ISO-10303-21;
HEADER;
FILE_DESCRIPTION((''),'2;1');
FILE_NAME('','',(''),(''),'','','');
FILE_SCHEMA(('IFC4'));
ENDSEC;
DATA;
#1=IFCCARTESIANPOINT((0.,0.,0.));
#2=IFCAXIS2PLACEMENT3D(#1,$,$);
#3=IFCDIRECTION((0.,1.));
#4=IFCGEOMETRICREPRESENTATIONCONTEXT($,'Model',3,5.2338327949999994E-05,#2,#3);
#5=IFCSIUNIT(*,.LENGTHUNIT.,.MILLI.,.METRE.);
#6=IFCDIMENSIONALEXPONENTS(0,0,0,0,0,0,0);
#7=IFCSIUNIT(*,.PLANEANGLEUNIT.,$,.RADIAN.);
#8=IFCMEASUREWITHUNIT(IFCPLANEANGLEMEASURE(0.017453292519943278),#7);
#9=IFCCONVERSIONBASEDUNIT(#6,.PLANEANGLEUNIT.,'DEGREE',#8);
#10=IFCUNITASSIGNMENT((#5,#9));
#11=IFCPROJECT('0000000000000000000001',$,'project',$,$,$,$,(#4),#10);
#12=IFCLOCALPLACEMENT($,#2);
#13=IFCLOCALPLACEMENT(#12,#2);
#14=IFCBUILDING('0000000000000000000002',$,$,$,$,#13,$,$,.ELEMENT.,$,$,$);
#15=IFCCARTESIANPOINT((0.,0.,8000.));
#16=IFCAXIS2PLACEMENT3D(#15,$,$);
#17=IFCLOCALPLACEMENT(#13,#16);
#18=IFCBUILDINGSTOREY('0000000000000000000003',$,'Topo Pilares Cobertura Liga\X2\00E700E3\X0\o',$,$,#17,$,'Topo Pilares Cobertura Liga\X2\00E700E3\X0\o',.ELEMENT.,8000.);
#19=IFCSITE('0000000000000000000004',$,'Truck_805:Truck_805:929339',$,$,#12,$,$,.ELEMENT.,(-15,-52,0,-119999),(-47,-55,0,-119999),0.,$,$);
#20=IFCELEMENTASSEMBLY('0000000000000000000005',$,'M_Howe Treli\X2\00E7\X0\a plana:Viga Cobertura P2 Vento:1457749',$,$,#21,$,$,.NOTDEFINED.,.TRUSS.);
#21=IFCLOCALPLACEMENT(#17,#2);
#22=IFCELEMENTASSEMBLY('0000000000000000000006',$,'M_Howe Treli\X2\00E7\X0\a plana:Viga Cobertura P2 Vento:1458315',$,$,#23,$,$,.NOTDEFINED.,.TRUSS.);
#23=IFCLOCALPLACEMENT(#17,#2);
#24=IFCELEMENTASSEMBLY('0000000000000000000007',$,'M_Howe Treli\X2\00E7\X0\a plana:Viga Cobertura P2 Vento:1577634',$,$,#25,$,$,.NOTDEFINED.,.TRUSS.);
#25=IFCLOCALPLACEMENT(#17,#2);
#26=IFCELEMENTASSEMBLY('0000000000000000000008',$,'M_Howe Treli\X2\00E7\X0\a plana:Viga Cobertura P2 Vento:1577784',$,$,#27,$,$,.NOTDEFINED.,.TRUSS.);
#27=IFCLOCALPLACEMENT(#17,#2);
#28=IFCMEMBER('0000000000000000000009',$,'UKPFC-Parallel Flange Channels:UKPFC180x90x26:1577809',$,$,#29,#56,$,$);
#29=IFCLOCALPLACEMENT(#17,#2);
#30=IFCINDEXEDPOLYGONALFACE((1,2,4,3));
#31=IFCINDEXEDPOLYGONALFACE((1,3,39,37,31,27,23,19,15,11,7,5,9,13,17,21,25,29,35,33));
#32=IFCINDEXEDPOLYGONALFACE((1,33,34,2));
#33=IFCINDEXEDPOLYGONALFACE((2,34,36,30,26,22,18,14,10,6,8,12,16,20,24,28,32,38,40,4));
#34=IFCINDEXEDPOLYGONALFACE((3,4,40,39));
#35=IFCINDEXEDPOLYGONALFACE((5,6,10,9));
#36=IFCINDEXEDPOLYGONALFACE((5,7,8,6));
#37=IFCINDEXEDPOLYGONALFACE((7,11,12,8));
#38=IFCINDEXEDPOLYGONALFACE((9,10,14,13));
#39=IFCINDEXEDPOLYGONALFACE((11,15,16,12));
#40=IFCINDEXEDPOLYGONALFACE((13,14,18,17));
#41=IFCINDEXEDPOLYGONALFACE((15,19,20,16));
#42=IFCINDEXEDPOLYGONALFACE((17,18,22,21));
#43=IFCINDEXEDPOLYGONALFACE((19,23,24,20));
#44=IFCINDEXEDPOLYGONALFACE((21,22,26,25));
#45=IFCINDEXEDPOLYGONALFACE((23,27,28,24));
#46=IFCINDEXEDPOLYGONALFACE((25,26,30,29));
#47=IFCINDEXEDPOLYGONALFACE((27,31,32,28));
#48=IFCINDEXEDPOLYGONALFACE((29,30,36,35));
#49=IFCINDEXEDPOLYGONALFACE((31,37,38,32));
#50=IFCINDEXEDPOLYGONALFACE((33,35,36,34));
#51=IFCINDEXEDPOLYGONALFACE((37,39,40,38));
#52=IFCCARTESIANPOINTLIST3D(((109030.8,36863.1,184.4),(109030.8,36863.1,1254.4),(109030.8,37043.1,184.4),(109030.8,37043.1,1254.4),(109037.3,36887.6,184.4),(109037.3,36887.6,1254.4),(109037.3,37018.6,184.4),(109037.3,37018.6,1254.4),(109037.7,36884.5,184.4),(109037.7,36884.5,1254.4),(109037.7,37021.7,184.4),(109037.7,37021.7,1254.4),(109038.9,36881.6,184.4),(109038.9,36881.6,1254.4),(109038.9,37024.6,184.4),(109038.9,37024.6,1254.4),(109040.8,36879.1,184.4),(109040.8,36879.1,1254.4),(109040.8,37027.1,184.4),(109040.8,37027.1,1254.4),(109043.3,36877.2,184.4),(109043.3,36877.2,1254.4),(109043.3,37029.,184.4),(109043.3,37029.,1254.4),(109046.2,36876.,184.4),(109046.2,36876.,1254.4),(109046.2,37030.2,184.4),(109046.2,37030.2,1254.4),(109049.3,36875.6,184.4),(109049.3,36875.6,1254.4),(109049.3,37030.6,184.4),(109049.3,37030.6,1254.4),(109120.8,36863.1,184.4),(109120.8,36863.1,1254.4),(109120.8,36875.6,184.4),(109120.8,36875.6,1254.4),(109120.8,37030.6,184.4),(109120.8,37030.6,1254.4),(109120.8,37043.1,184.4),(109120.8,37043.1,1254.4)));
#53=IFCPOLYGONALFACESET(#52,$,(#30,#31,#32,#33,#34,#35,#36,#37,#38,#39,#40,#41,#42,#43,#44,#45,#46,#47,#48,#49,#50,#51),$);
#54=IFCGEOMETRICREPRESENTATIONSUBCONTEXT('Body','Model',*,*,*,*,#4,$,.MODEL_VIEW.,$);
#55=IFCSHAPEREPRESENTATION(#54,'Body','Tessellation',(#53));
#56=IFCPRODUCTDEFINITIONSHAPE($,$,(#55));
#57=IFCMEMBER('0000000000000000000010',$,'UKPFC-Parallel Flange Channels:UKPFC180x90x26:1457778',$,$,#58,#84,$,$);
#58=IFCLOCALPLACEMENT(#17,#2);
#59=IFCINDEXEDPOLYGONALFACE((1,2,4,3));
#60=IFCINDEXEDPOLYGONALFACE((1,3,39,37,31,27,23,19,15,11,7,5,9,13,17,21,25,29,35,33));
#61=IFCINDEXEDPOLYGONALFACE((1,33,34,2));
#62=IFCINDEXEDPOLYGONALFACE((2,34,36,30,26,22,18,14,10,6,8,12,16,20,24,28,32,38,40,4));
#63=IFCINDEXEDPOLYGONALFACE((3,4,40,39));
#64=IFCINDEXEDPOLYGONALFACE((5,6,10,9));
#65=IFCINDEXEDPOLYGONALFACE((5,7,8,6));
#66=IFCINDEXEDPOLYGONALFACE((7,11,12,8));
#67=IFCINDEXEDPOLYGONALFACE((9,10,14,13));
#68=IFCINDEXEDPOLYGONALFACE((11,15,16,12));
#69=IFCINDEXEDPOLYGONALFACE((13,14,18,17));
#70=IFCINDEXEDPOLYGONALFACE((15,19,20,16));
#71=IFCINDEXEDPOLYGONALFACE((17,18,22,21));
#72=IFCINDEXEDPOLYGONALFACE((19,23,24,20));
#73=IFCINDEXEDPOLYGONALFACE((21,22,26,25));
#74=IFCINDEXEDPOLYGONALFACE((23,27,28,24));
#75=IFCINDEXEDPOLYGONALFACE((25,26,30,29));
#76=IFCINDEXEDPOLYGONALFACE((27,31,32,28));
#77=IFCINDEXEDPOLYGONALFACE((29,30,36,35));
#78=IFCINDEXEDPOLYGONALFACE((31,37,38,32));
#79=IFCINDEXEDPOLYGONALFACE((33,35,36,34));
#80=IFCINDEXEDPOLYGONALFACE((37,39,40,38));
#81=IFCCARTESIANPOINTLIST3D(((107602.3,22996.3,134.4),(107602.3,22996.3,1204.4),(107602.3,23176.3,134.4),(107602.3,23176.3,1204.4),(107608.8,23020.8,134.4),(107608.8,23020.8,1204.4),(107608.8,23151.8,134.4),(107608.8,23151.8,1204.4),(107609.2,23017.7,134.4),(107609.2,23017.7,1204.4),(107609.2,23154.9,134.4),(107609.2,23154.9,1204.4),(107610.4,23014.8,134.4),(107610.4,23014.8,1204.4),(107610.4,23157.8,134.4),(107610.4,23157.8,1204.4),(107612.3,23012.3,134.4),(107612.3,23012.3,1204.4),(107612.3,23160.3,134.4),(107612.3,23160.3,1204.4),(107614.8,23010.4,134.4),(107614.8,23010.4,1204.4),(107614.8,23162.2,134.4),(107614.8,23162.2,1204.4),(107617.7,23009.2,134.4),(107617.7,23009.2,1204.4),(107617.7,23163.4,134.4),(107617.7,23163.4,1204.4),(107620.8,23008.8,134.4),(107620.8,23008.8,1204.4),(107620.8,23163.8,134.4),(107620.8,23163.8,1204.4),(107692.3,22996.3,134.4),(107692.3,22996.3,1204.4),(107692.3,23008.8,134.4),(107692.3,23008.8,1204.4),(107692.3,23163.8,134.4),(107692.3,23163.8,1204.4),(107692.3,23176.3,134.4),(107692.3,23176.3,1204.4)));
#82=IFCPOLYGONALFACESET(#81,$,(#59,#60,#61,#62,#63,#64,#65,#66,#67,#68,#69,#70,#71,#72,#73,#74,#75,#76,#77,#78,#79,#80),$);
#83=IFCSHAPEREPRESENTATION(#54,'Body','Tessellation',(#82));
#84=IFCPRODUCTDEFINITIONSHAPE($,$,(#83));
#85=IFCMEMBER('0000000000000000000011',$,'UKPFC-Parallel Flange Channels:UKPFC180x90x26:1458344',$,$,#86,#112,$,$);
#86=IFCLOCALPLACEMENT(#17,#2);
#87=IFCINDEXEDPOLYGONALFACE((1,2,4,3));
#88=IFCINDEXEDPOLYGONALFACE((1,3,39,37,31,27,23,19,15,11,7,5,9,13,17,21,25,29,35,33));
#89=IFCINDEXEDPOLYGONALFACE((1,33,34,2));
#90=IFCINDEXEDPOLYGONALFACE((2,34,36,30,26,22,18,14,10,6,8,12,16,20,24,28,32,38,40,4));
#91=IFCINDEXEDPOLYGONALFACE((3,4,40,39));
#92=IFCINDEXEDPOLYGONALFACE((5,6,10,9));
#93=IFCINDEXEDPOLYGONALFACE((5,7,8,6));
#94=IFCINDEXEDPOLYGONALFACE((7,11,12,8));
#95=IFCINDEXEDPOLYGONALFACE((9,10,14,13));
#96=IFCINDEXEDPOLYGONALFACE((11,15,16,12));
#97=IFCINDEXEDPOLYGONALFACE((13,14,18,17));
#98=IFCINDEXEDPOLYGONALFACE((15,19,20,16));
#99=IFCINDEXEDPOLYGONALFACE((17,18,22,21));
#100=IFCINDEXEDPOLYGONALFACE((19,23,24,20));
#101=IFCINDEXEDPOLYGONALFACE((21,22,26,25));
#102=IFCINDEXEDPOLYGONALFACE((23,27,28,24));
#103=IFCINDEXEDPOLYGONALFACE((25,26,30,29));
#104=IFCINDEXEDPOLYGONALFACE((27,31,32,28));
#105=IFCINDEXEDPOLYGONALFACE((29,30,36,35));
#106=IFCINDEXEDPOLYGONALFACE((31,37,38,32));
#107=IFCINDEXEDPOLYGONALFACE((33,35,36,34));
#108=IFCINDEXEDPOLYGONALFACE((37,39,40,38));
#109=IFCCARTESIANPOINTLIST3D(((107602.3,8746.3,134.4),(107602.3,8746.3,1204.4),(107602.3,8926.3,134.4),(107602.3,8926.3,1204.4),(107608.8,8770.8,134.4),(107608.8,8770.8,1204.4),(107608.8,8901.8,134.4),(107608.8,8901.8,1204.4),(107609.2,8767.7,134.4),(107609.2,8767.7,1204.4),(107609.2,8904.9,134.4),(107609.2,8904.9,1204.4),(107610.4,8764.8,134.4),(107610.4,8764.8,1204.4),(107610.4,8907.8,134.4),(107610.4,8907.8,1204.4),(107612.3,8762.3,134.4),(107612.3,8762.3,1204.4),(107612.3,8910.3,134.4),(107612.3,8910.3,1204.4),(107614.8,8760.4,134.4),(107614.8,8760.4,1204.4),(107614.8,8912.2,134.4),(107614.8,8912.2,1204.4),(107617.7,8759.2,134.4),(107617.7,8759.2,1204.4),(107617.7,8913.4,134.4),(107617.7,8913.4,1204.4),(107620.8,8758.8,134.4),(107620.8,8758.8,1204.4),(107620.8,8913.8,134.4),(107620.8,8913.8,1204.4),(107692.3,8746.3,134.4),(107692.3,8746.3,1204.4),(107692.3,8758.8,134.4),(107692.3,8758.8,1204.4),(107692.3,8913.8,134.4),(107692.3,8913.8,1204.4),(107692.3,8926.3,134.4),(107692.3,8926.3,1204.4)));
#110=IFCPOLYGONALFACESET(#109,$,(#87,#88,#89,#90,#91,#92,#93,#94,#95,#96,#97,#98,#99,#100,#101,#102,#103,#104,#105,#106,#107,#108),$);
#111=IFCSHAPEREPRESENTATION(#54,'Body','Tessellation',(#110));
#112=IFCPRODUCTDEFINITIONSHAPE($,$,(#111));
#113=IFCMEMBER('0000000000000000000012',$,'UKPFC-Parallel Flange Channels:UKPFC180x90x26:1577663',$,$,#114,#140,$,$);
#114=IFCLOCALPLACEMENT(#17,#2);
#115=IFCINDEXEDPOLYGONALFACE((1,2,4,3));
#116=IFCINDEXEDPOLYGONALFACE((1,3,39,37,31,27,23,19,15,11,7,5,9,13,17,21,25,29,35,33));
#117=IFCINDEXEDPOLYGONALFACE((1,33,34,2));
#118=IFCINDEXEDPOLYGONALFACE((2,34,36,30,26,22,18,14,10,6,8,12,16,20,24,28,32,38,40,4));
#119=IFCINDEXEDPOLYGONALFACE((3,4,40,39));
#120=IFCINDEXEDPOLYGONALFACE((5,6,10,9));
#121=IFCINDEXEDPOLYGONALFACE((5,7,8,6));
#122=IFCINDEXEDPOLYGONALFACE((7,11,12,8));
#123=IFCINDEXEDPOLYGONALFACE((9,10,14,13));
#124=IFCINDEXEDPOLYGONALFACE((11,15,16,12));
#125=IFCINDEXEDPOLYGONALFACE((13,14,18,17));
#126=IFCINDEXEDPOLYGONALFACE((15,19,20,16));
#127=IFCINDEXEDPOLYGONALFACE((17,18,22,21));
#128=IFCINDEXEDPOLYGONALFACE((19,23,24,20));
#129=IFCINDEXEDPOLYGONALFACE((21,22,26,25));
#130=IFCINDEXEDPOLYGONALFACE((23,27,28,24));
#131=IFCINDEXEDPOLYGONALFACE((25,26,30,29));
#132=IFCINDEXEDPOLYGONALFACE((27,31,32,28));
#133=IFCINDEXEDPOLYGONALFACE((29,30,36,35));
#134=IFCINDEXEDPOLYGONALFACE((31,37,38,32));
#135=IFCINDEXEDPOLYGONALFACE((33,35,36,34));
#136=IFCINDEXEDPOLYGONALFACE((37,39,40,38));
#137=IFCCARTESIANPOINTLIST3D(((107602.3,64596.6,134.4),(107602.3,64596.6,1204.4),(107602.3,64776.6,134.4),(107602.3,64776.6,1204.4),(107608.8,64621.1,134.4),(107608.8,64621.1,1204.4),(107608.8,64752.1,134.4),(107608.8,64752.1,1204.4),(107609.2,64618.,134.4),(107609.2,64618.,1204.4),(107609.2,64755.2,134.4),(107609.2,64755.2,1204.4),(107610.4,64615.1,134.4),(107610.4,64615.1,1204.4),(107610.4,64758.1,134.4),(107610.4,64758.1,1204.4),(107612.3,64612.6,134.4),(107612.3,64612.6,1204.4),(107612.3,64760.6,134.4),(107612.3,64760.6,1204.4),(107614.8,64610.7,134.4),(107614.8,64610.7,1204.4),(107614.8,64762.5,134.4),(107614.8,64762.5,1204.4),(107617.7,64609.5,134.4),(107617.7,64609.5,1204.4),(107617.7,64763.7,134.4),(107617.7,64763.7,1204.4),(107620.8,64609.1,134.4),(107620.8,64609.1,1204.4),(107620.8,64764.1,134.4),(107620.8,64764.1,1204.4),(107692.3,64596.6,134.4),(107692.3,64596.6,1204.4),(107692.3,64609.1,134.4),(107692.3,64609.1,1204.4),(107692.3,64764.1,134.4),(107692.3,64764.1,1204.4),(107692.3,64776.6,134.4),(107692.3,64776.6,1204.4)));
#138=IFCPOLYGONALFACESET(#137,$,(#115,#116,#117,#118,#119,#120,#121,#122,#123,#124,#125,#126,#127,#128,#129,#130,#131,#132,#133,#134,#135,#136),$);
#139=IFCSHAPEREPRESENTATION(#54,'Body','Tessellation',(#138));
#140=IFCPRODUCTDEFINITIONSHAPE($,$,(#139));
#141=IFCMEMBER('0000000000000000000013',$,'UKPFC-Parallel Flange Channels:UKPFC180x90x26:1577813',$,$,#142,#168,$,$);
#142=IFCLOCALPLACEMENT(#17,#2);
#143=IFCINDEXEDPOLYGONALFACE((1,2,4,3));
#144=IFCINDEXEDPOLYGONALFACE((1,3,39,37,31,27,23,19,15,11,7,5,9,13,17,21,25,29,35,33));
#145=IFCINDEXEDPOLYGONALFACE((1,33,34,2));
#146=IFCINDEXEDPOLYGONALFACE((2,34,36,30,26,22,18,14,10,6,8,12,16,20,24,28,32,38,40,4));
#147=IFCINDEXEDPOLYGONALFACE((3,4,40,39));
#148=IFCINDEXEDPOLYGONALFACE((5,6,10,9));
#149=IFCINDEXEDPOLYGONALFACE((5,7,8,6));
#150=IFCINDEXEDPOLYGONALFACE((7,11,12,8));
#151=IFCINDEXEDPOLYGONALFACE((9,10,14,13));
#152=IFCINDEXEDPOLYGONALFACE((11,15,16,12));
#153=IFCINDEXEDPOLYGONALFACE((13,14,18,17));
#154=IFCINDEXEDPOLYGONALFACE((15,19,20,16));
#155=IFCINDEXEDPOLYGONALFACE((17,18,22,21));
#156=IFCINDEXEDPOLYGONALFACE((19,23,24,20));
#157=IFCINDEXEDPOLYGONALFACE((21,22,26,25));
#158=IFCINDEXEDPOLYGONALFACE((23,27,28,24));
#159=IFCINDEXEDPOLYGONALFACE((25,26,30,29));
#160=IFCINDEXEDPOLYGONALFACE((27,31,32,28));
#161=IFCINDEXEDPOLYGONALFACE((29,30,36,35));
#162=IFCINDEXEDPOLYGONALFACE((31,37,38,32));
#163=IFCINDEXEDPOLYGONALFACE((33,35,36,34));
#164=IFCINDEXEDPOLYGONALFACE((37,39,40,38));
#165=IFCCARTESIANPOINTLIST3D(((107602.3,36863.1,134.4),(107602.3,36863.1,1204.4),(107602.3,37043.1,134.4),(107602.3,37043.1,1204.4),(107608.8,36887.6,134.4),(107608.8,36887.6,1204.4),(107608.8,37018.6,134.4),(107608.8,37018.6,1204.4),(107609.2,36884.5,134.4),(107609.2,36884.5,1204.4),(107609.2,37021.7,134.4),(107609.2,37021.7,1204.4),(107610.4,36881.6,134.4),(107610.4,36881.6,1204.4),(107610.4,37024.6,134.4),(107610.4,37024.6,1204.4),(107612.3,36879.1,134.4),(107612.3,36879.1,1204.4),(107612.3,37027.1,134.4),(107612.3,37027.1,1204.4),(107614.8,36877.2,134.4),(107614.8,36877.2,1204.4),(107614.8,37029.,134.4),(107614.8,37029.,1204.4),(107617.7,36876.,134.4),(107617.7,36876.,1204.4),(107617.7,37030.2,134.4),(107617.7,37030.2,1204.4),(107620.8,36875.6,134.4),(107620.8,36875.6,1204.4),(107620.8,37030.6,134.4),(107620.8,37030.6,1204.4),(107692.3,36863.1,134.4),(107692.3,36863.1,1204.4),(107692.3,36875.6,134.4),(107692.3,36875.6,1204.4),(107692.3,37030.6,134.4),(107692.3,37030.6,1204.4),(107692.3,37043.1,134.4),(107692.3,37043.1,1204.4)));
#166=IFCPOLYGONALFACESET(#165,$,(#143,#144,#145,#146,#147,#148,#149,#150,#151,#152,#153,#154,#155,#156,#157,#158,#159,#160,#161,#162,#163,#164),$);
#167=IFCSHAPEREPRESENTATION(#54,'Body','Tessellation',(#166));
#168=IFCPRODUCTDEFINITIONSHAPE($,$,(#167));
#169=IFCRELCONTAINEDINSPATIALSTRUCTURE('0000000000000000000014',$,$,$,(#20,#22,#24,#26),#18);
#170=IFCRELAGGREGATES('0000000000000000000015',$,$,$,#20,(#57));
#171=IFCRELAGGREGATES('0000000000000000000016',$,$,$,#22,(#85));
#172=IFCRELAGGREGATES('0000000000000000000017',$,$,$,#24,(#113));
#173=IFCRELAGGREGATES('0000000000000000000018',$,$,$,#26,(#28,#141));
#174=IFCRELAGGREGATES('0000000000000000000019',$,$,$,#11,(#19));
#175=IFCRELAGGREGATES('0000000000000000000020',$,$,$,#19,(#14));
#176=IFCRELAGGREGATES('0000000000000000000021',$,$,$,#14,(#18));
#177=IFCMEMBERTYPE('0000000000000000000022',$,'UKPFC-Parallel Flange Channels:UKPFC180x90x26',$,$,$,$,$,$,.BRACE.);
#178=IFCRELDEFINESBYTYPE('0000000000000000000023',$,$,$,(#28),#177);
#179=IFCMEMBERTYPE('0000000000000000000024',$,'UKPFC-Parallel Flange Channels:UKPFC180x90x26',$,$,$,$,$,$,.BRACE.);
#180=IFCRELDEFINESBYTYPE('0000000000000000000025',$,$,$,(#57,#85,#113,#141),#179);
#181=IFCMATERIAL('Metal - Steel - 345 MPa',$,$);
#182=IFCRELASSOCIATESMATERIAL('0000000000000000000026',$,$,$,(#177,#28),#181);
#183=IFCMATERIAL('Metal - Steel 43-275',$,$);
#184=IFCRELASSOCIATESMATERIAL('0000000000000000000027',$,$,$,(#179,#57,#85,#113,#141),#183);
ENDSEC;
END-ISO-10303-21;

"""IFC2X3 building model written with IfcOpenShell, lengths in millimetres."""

from ifc_helpers import new_model, entity, si_unit, converted_unit, direction, frame, frame_2d, origin, place, context, subcontext, project, spatial, polyline, circle_curve, parameter, trimmed, segment, composite_curve, outline, extrude, source, transform, mapped, material, type_object, type_shapes, element, aggregate, save


model = new_model("IFC2X3")

# Units and contexts
model_context = context("Model", 3, precision=5.2338327949999994e-05, world=origin(), true_north=direction((0.0, 1.0)))
body_context = subcontext(model_context, "Body", "Model", "MODEL_VIEW")
ifc_project = project(units=[si_unit("LENGTHUNIT", "METRE", prefix="MILLI"), converted_unit("PLANEANGLEUNIT", "DEGREE", entity("IfcPlaneAngleMeasure", 0.017453292519943278), si_unit("PLANEANGLEUNIT", "RADIAN"), dimensions=[0, 0, 0, 0, 0, 0, 0])], contexts=[model_context])

# Site, building, storey
site_placement = place(None, origin())
site = spatial("IfcSite", under=ifc_project, at=site_placement, Name="Truck_805:Truck_805:929339", CompositionType="ELEMENT", RefLatitude=(-15, -52, 0, -119999), RefLongitude=(-47, -55, 0, -119999), RefElevation=0.0)
building_placement = place(site_placement, origin())
building = spatial("IfcBuilding", under=site, at=building_placement, CompositionType="ELEMENT")
storey_placement = place(building_placement, frame((0.0, 0.0, 8000.0)))
storey = spatial("IfcBuildingStorey", under=building, at=storey_placement, Name="Topo Pilares Cobertura Ligação", LongName="Topo Pilares Cobertura Ligação", CompositionType="ELEMENT", Elevation=8000.0)

# Element assemblies
assembly_1_placement = place(storey_placement, origin())
assembly_1 = element("IfcElementAssembly", 1, at=assembly_1_placement, inside=storey, Name="M_Howe Treliça plana:Viga Cobertura P2 Vento:1457749", AssemblyPlace="NOTDEFINED", PredefinedType="TRUSS")
assembly_2_placement = place(storey_placement, origin())
assembly_2 = element("IfcElementAssembly", 2, at=assembly_2_placement, inside=storey, Name="M_Howe Treliça plana:Viga Cobertura P2 Vento:1458315", AssemblyPlace="NOTDEFINED", PredefinedType="TRUSS")
assembly_3_placement = place(storey_placement, origin())
assembly_3 = element("IfcElementAssembly", 3, at=assembly_3_placement, inside=storey, Name="M_Howe Treliça plana:Viga Cobertura P2 Vento:1577634", AssemblyPlace="NOTDEFINED", PredefinedType="TRUSS")
assembly_4_placement = place(storey_placement, origin())
assembly_4 = element("IfcElementAssembly", 4, at=assembly_4_placement, inside=storey, Name="M_Howe Treliça plana:Viga Cobertura P2 Vento:1577784", AssemblyPlace="NOTDEFINED", PredefinedType="TRUSS")

# Members
ifc_material_1 = material(Name="Metal - Steel - 345 MPa")
member_type_1 = type_object("IfcMemberType", Name="UKPFC-Parallel Flange Channels:UKPFC180x90x26", PredefinedType="BRACE", material=ifc_material_1)
shared_shape_1 = source(origin(), body_context, "Body", "SweptSolid", [
    extrude(outline(composite_curve([segment(polyline([(-90.0, -41.0), (90.0, -41.0)]), True, "CONTINUOUS"), segment(polyline([(90.0, -41.0), (90.0, 49.0)]), True, "CONTINUOUS"), segment(polyline([(90.0, 49.0), (77.5, 49.0)]), True, "CONTINUOUS"), segment(polyline([(77.5, 49.0), (77.5, -22.5)]), True, "CONTINUOUS"), segment(trimmed(circle_curve(frame_2d((65.5, -22.5), x_axis=(1.0, 0.0)), 12.0), [parameter(270.0)], [parameter(0.0)], True, "PARAMETER"), False, "CONTINUOUS"), segment(polyline([(65.5, -34.5), (-65.5, -34.5)]), True, "CONTINUOUS"), segment(trimmed(circle_curve(frame_2d((-65.5, -22.5), x_axis=(0.0, -1.0)), 12.0), [parameter(270.0)], [parameter(0.0)], True, "PARAMETER"), False, "CONTINUOUS"), segment(polyline([(-77.5, -22.5), (-77.5, 49.0)]), True, "CONTINUOUS"), segment(polyline([(-77.5, 49.0), (-90.0, 49.0)]), True, "CONTINUOUS"), segment(polyline([(-90.0, 49.0), (-90.0, -41.0)]), True, "CONTINUOUS")], self_intersect=False)), frame((-535.0, 9.3, 0.0), z_axis=(1.0, 0.0, 0.0), x_axis=(0.0, 0.0, -1.0)), (0.0, 0.0, 1.0), 1070.0),
])
type_shapes(member_type_1, [shared_shape_1])
member_1_placement = place(assembly_4_placement, frame((109062.5, 36953.1, 719.4), z_axis=(0.0, 1.0, 0.0), x_axis=(0.0, 0.0, 1.0)))
member_1 = element("IfcMember", 5, at=member_1_placement, type_object=member_type_1, material=ifc_material_1, Name="UKPFC-Parallel Flange Channels:UKPFC180x90x26:1577809", context=body_context, shape_type="MappedRepresentation", body=[
    mapped(shared_shape_1, transform((0.0, 0.0, 0.0), scale=1.0)),
])
ifc_material_2 = material(Name="Metal - Steel 43-275")
member_type_2 = type_object("IfcMemberType", Name="UKPFC-Parallel Flange Channels:UKPFC180x90x26", PredefinedType="BRACE", material=ifc_material_2)
shared_shape_2 = source(origin(), body_context, "Body", "SweptSolid", [
    extrude(outline(composite_curve([segment(polyline([(-90.0, -49.0), (-77.5, -49.0)]), True, "CONTINUOUS"), segment(polyline([(-77.5, -49.0), (-77.5, 22.5)]), True, "CONTINUOUS"), segment(trimmed(circle_curve(frame_2d((-65.5, 22.5), x_axis=(-1.0, 0.0)), 12.0), [parameter(270.0)], [parameter(0.0)], True, "PARAMETER"), False, "CONTINUOUS"), segment(polyline([(-65.5, 34.5), (65.5, 34.5)]), True, "CONTINUOUS"), segment(trimmed(circle_curve(frame_2d((65.5, 22.5), x_axis=(0.0, 1.0)), 12.0), [parameter(270.0)], [parameter(0.0)], True, "PARAMETER"), False, "CONTINUOUS"), segment(polyline([(77.5, 22.5), (77.5, -49.0)]), True, "CONTINUOUS"), segment(polyline([(77.5, -49.0), (90.0, -49.0)]), True, "CONTINUOUS"), segment(polyline([(90.0, -49.0), (90.0, 41.0)]), True, "CONTINUOUS"), segment(polyline([(90.0, 41.0), (-90.0, 41.0)]), True, "CONTINUOUS"), segment(polyline([(-90.0, 41.0), (-90.0, -49.0)]), True, "CONTINUOUS")], self_intersect=False)), frame((-535.0, -9.3, 0.0), z_axis=(1.0, 0.0, 0.0), x_axis=(0.0, 0.0, -1.0)), (0.0, 0.0, 1.0), 1070.0),
])
type_shapes(member_type_2, [shared_shape_2])
member_2_placement = place(assembly_1_placement, frame((107634.0, 23086.3, 669.4), z_axis=(0.0, -1.0, 0.0), x_axis=(0.0, 0.0, 1.0)))
member_2 = element("IfcMember", 6, at=member_2_placement, type_object=member_type_2, material=ifc_material_2, Name="UKPFC-Parallel Flange Channels:UKPFC180x90x26:1457778", context=body_context, shape_type="MappedRepresentation", body=[
    mapped(shared_shape_2, transform((0.0, 0.0, 0.0), scale=1.0)),
])
member_3_placement = place(assembly_2_placement, frame((107634.0, 8836.3, 669.4), z_axis=(0.0, -1.0, 0.0), x_axis=(0.0, 0.0, 1.0)))
member_3 = element("IfcMember", 7, at=member_3_placement, type_object=member_type_2, material=ifc_material_2, Name="UKPFC-Parallel Flange Channels:UKPFC180x90x26:1458344", context=body_context, shape_type="MappedRepresentation", body=[
    mapped(shared_shape_2, transform((0.0, 0.0, 0.0), scale=1.0)),
])
member_4_placement = place(assembly_3_placement, frame((107634.0, 64686.6, 669.4), z_axis=(0.0, -1.0, 0.0), x_axis=(0.0, 0.0, 1.0)))
member_4 = element("IfcMember", 8, at=member_4_placement, type_object=member_type_2, material=ifc_material_2, Name="UKPFC-Parallel Flange Channels:UKPFC180x90x26:1577663", context=body_context, shape_type="MappedRepresentation", body=[
    mapped(shared_shape_2, transform((0.0, 0.0, 0.0), scale=1.0)),
])
member_5_placement = place(assembly_4_placement, frame((107634.0, 36953.1, 669.4), z_axis=(0.0, -1.0, 0.0), x_axis=(0.0, 0.0, 1.0)))
member_5 = element("IfcMember", 9, at=member_5_placement, type_object=member_type_2, material=ifc_material_2, Name="UKPFC-Parallel Flange Channels:UKPFC180x90x26:1577813", context=body_context, shape_type="MappedRepresentation", body=[
    mapped(shared_shape_2, transform((0.0, 0.0, 0.0), scale=1.0)),
])
aggregate(assembly_1, [member_2])
aggregate(assembly_2, [member_3])
aggregate(assembly_3, [member_4])
aggregate(assembly_4, [member_1, member_5])

save(model, "model.ifc")
